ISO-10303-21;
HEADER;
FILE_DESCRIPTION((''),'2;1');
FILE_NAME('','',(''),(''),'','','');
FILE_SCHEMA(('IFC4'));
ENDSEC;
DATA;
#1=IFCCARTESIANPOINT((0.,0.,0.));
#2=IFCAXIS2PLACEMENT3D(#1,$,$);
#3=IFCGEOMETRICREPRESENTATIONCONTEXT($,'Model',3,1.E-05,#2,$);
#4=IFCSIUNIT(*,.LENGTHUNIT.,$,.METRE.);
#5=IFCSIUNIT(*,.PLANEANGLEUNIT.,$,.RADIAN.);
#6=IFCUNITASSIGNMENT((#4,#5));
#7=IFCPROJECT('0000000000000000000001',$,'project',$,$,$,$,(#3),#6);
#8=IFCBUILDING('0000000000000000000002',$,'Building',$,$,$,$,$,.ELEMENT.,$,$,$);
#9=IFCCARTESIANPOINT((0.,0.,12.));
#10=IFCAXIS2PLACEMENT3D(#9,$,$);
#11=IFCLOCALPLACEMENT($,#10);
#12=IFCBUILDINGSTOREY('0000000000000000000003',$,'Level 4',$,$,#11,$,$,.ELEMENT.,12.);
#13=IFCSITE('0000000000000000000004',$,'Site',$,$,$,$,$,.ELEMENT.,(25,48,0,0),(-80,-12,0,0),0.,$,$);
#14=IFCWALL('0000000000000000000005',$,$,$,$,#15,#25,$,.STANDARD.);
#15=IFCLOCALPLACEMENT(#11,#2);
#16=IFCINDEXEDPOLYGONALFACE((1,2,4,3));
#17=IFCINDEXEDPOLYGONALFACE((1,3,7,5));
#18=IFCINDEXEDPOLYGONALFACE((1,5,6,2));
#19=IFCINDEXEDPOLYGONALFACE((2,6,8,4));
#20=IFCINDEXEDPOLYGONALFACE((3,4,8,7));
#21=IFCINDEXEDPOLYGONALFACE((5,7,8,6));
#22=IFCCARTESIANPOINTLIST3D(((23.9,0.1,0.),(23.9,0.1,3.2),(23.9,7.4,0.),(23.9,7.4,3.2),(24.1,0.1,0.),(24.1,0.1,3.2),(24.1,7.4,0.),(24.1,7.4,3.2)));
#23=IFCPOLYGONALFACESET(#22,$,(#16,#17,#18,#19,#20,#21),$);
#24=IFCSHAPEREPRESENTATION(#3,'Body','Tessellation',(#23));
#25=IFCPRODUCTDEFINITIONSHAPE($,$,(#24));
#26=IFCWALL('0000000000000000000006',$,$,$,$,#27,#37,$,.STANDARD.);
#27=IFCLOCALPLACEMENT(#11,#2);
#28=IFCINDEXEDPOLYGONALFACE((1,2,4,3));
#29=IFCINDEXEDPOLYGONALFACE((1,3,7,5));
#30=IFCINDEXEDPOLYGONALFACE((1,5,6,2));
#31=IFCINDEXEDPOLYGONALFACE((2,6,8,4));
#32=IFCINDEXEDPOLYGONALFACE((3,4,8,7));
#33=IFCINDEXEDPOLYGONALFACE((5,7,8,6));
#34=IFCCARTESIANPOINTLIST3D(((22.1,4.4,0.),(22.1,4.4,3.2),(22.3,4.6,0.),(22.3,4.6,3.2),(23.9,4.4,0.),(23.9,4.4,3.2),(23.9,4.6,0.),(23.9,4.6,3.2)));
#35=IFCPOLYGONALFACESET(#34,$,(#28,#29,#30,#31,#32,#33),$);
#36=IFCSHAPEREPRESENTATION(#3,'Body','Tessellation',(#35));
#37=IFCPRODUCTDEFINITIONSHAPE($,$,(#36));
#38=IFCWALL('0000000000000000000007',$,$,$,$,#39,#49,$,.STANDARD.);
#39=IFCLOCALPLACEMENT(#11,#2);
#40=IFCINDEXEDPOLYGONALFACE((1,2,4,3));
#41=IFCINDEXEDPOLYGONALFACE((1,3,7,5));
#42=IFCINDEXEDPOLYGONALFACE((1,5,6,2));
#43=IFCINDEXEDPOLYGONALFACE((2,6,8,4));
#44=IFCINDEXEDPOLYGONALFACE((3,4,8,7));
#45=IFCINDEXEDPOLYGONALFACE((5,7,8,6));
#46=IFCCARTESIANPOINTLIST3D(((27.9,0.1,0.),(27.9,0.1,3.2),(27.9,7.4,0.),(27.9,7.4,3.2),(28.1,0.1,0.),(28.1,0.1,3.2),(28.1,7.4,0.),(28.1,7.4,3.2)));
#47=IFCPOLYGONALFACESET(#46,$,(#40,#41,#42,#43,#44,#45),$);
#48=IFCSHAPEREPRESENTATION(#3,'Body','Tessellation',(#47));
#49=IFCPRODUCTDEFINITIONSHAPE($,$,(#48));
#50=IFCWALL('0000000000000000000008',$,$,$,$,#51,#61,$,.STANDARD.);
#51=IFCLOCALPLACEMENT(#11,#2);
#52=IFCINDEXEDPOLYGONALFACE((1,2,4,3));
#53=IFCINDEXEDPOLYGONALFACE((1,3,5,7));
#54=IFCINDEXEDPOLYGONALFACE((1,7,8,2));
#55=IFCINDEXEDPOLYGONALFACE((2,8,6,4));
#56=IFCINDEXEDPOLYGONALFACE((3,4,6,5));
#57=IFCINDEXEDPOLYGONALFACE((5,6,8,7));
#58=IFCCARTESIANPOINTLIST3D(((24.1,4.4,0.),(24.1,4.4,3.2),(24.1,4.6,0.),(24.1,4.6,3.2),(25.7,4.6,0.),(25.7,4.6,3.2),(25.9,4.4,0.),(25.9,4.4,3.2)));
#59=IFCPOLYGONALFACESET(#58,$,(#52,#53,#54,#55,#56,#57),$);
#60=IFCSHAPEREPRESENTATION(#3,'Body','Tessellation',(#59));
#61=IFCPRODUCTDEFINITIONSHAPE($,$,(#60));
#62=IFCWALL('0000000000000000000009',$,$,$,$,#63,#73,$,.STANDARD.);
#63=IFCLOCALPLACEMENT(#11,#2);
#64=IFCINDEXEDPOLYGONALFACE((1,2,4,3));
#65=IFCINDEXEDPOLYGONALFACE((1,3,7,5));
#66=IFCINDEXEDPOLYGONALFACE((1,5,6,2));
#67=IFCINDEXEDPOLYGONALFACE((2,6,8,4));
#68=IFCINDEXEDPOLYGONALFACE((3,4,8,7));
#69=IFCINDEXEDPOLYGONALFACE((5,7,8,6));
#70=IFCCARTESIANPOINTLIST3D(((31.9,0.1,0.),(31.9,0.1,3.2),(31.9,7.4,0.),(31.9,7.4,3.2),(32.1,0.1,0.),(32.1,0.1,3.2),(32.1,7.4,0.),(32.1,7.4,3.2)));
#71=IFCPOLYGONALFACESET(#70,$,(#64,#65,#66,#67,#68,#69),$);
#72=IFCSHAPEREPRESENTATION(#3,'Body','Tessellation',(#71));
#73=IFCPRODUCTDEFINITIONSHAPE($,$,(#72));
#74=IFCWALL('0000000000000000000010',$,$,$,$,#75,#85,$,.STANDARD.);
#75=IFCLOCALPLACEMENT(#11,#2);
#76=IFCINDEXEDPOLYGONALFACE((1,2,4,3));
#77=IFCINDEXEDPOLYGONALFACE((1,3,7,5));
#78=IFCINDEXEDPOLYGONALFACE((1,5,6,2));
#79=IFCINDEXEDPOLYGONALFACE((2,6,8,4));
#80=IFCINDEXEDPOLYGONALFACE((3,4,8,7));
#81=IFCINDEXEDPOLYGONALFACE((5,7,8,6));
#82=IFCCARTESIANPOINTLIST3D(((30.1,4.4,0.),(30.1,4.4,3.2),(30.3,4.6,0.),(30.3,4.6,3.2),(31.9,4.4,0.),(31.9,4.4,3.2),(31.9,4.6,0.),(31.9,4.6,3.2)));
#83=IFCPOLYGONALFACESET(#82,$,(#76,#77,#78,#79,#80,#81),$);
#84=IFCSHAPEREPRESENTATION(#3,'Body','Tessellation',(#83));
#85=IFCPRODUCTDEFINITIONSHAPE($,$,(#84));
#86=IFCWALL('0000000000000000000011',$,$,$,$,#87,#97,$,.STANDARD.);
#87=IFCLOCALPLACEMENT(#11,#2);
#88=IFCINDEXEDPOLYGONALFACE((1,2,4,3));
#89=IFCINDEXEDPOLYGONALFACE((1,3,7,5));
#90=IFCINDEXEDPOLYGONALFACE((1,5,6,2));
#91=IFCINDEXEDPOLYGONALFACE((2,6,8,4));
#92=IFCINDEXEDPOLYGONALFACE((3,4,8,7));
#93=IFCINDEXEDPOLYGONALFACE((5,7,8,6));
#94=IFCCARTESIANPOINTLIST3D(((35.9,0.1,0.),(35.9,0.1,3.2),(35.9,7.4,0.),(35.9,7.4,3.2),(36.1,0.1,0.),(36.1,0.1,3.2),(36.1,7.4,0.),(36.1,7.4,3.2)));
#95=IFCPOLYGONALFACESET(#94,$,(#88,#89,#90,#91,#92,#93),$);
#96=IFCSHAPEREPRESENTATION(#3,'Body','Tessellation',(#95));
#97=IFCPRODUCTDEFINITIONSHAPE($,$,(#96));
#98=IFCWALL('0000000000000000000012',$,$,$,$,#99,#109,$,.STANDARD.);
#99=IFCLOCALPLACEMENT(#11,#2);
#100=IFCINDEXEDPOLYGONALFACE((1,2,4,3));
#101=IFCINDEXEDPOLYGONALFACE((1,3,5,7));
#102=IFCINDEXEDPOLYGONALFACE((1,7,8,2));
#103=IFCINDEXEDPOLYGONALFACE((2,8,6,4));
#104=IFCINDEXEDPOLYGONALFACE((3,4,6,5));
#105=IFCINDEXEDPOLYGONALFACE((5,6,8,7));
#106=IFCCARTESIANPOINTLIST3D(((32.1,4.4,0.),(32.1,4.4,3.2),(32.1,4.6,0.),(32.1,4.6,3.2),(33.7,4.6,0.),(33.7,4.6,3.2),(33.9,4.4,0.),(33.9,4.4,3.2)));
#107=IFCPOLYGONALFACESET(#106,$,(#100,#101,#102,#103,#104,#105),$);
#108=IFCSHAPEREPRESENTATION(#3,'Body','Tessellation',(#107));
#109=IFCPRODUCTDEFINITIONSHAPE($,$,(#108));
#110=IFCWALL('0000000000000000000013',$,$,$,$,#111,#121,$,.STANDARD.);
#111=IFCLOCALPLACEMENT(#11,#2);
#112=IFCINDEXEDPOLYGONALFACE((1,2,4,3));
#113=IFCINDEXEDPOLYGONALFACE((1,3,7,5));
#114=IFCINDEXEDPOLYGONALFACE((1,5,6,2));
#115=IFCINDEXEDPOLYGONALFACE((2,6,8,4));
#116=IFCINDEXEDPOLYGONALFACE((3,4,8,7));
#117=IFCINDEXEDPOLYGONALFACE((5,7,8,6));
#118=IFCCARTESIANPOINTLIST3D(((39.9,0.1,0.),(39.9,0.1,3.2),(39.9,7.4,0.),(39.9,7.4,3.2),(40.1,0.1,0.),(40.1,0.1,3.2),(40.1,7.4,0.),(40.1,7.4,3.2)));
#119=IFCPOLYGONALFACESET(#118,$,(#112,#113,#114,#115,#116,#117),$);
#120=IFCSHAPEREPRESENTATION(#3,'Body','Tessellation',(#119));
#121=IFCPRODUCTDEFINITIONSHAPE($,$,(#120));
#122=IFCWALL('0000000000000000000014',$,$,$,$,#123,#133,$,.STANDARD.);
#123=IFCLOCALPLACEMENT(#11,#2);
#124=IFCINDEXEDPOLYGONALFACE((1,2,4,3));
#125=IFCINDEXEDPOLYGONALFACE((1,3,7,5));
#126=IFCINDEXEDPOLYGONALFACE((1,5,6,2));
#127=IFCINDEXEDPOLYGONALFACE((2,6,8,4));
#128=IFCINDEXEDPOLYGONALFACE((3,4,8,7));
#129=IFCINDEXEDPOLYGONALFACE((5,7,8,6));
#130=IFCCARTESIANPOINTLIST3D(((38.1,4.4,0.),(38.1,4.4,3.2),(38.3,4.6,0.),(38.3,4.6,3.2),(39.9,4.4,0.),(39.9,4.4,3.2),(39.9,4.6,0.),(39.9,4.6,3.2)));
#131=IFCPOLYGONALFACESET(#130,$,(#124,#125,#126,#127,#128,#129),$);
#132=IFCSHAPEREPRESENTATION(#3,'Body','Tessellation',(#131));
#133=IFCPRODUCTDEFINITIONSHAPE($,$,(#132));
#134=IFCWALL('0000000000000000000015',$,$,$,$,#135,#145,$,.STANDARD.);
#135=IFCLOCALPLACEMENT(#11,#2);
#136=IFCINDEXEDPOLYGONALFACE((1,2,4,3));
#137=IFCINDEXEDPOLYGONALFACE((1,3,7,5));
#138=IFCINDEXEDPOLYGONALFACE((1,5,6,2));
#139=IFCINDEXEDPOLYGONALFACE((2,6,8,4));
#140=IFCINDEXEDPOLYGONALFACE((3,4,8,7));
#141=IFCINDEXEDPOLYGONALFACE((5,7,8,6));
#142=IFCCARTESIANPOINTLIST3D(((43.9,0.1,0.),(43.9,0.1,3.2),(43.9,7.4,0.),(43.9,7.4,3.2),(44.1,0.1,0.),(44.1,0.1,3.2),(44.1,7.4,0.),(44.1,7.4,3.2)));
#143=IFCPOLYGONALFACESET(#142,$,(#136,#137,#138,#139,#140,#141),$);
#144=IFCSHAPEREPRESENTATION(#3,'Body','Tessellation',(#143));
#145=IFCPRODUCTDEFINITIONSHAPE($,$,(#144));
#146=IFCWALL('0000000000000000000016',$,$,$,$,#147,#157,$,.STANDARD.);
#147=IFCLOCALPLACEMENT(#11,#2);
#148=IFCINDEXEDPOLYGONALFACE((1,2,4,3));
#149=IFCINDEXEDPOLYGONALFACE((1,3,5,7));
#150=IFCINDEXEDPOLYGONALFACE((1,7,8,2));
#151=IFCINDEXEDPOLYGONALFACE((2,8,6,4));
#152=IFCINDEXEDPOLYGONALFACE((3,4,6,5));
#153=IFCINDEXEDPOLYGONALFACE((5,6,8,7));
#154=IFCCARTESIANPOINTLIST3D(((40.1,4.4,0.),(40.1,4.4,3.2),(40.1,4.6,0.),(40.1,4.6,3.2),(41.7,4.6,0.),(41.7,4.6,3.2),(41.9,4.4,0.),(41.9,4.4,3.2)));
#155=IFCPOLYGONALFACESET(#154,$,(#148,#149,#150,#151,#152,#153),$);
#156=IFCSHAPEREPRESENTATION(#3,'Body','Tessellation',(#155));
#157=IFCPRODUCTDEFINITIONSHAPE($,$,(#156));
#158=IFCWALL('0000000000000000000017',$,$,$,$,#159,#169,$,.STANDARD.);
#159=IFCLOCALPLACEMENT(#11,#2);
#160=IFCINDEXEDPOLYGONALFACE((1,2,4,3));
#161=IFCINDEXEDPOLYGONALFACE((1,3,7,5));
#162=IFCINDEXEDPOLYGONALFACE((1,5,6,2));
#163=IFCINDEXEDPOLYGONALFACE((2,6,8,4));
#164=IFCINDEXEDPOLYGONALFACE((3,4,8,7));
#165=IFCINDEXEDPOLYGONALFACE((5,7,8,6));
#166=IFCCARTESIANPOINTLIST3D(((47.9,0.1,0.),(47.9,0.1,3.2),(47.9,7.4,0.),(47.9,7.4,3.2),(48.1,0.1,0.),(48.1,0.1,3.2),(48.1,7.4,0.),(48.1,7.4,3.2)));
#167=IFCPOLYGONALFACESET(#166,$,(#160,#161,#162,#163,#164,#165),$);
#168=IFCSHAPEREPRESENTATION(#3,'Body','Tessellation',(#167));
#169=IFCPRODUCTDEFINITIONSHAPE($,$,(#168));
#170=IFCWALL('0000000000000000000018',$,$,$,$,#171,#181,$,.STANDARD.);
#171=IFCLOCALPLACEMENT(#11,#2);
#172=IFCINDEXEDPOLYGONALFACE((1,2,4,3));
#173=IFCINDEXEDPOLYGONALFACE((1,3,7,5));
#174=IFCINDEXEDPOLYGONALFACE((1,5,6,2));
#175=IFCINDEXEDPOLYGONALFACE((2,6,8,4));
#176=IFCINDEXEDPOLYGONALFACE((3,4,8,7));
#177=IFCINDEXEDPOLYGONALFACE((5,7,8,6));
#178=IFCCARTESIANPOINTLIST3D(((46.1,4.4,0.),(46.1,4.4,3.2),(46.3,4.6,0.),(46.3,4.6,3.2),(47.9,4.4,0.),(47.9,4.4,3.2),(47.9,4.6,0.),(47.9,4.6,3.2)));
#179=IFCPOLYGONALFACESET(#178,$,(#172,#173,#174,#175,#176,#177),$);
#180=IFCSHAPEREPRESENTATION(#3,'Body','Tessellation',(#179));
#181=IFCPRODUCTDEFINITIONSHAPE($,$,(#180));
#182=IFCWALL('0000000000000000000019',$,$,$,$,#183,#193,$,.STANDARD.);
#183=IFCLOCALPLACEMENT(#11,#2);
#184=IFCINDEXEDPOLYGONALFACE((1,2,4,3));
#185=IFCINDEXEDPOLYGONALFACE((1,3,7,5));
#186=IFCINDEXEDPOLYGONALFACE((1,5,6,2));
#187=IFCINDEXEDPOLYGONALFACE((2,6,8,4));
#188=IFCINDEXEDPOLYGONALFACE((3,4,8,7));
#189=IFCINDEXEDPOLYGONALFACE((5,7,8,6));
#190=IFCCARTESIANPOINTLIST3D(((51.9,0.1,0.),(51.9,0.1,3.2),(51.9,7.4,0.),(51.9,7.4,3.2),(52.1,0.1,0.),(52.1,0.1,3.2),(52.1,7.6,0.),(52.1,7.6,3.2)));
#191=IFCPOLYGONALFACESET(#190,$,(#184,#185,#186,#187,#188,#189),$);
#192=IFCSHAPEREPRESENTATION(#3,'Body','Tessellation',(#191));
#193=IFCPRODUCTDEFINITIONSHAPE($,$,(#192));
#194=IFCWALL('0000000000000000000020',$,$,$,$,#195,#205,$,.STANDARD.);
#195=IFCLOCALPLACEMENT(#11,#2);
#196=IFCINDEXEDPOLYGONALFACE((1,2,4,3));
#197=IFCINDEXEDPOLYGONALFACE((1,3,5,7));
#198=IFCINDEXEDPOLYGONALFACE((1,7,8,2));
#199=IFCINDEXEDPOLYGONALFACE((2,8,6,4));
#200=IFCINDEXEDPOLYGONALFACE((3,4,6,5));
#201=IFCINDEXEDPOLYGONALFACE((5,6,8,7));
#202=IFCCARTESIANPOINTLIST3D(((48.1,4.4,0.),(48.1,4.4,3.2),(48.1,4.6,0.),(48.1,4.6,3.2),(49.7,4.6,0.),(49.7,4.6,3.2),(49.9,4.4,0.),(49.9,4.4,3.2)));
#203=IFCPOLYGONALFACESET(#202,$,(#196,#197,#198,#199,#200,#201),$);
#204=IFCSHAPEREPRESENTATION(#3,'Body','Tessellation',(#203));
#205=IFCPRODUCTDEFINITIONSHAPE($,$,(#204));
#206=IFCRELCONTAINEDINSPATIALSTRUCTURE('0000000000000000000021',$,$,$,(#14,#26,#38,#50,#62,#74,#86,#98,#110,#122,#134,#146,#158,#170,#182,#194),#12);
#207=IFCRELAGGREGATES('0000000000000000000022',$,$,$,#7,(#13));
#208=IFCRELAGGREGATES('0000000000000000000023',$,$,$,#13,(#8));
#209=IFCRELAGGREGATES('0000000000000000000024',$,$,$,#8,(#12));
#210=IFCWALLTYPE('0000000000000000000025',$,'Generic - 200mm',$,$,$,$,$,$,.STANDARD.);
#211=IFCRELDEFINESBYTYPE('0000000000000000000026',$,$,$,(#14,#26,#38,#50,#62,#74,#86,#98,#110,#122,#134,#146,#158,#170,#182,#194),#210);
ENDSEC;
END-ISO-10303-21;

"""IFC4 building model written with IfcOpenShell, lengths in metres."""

from ifc_helpers import new_model, si_unit, frame, origin, place, context, project, spatial, polyline, outline, extrude, type_object, element, save


model = new_model("IFC4")

# Units and contexts
model_context = context("Model", 3, precision=1e-05, world=origin())
ifc_project = project(units=[si_unit("LENGTHUNIT", "METRE"), si_unit("PLANEANGLEUNIT", "RADIAN")], contexts=[model_context])

# Site, building, storey
site = spatial("IfcSite", under=ifc_project, Name="Site", CompositionType="ELEMENT", RefLatitude=(25, 48, 0, 0), RefLongitude=(-80, -12, 0, 0), RefElevation=0.0)
building = spatial("IfcBuilding", under=site, Name="Building", CompositionType="ELEMENT")
storey_placement = place(None, frame((0.0, 0.0, 12.0)))
storey = spatial("IfcBuildingStorey", under=building, at=storey_placement, Name="Level 4", CompositionType="ELEMENT", Elevation=12.0)

# Shared definitions
wall_type = type_object("IfcWallType", Name="Generic - 200mm", PredefinedType="STANDARD")

# Walls
wall_1_placement = place(None, frame((24.0, 7.5, 12.0), z_axis=(0.0, 0.0, 1.0), x_axis=(0.0, -1.0, 0.0)))
element("IfcWall", 1, at=wall_1_placement, inside=storey, type_object=wall_type, PredefinedType="STANDARD", context=model_context, shape_type="SweptSolid", body=[
    extrude(outline(polyline([(0.1, -0.1), (7.4, -0.1), (7.4, 0.1), (0.1, 0.1), (0.1, -0.1)])), origin(), (0.0, 0.0, 1.0), 3.2),
])
wall_2_placement = place(None, frame((22.2, 4.5, 12.0), z_axis=(0.0, 0.0, 1.0), x_axis=(1.0, 0.0, 0.0)))
element("IfcWall", 2, at=wall_2_placement, inside=storey, type_object=wall_type, PredefinedType="STANDARD", context=model_context, shape_type="SweptSolid", body=[
    extrude(outline(polyline([(-0.1, -0.1), (1.7, -0.1), (1.7, 0.1), (0.1, 0.1), (-0.1, -0.1)])), origin(), (0.0, 0.0, 1.0), 3.2),
])
wall_3_placement = place(None, frame((28.0, 7.5, 12.0), z_axis=(0.0, 0.0, 1.0), x_axis=(0.0, -1.0, 0.0)))
element("IfcWall", 3, at=wall_3_placement, inside=storey, type_object=wall_type, PredefinedType="STANDARD", context=model_context, shape_type="SweptSolid", body=[
    extrude(outline(polyline([(0.1, -0.1), (7.4, -0.1), (7.4, 0.1), (0.1, 0.1), (0.1, -0.1)])), origin(), (0.0, 0.0, 1.0), 3.2),
])
wall_4_placement = place(None, frame((25.8, 4.5, 12.0), z_axis=(0.0, 0.0, 1.0), x_axis=(-1.0, 0.0, 0.0)))
element("IfcWall", 4, at=wall_4_placement, inside=storey, type_object=wall_type, PredefinedType="STANDARD", context=model_context, shape_type="SweptSolid", body=[
    extrude(outline(polyline([(0.1, -0.1), (1.7, -0.1), (1.7, 0.1), (-0.1, 0.1), (0.1, -0.1)])), origin(), (0.0, 0.0, 1.0), 3.2),
])
wall_5_placement = place(None, frame((32.0, 7.5, 12.0), z_axis=(0.0, 0.0, 1.0), x_axis=(0.0, -1.0, 0.0)))
element("IfcWall", 5, at=wall_5_placement, inside=storey, type_object=wall_type, PredefinedType="STANDARD", context=model_context, shape_type="SweptSolid", body=[
    extrude(outline(polyline([(0.1, -0.1), (7.4, -0.1), (7.4, 0.1), (0.1, 0.1), (0.1, -0.1)])), origin(), (0.0, 0.0, 1.0), 3.2),
])
wall_6_placement = place(None, frame((30.2, 4.5, 12.0), z_axis=(0.0, 0.0, 1.0), x_axis=(1.0, 0.0, 0.0)))
element("IfcWall", 6, at=wall_6_placement, inside=storey, type_object=wall_type, PredefinedType="STANDARD", context=model_context, shape_type="SweptSolid", body=[
    extrude(outline(polyline([(-0.1, -0.1), (1.7, -0.1), (1.7, 0.1), (0.1, 0.1), (-0.1, -0.1)])), origin(), (0.0, 0.0, 1.0), 3.2),
])
wall_7_placement = place(None, frame((36.0, 7.5, 12.0), z_axis=(0.0, 0.0, 1.0), x_axis=(0.0, -1.0, 0.0)))
element("IfcWall", 7, at=wall_7_placement, inside=storey, type_object=wall_type, PredefinedType="STANDARD", context=model_context, shape_type="SweptSolid", body=[
    extrude(outline(polyline([(0.1, -0.1), (7.4, -0.1), (7.4, 0.1), (0.1, 0.1), (0.1, -0.1)])), origin(), (0.0, 0.0, 1.0), 3.2),
])
wall_8_placement = place(None, frame((33.8, 4.5, 12.0), z_axis=(0.0, 0.0, 1.0), x_axis=(-1.0, 0.0, 0.0)))
element("IfcWall", 8, at=wall_8_placement, inside=storey, type_object=wall_type, PredefinedType="STANDARD", context=model_context, shape_type="SweptSolid", body=[
    extrude(outline(polyline([(0.1, -0.1), (1.7, -0.1), (1.7, 0.1), (-0.1, 0.1), (0.1, -0.1)])), origin(), (0.0, 0.0, 1.0), 3.2),
])
wall_9_placement = place(None, frame((40.0, 7.5, 12.0), z_axis=(0.0, 0.0, 1.0), x_axis=(0.0, -1.0, 0.0)))
element("IfcWall", 9, at=wall_9_placement, inside=storey, type_object=wall_type, PredefinedType="STANDARD", context=model_context, shape_type="SweptSolid", body=[
    extrude(outline(polyline([(0.1, -0.1), (7.4, -0.1), (7.4, 0.1), (0.1, 0.1), (0.1, -0.1)])), origin(), (0.0, 0.0, 1.0), 3.2),
])
wall_10_placement = place(None, frame((38.2, 4.5, 12.0), z_axis=(0.0, 0.0, 1.0), x_axis=(1.0, 0.0, 0.0)))
element("IfcWall", 10, at=wall_10_placement, inside=storey, type_object=wall_type, PredefinedType="STANDARD", context=model_context, shape_type="SweptSolid", body=[
    extrude(outline(polyline([(-0.1, -0.1), (1.7, -0.1), (1.7, 0.1), (0.1, 0.1), (-0.1, -0.1)])), origin(), (0.0, 0.0, 1.0), 3.2),
])
wall_11_placement = place(None, frame((44.0, 7.5, 12.0), z_axis=(0.0, 0.0, 1.0), x_axis=(0.0, -1.0, 0.0)))
element("IfcWall", 11, at=wall_11_placement, inside=storey, type_object=wall_type, PredefinedType="STANDARD", context=model_context, shape_type="SweptSolid", body=[
    extrude(outline(polyline([(0.1, -0.1), (7.4, -0.1), (7.4, 0.1), (0.1, 0.1), (0.1, -0.1)])), origin(), (0.0, 0.0, 1.0), 3.2),
])
wall_12_placement = place(None, frame((41.8, 4.5, 12.0), z_axis=(0.0, 0.0, 1.0), x_axis=(-1.0, 0.0, 0.0)))
element("IfcWall", 12, at=wall_12_placement, inside=storey, type_object=wall_type, PredefinedType="STANDARD", context=model_context, shape_type="SweptSolid", body=[
    extrude(outline(polyline([(0.1, -0.1), (1.7, -0.1), (1.7, 0.1), (-0.1, 0.1), (0.1, -0.1)])), origin(), (0.0, 0.0, 1.0), 3.2),
])
wall_13_placement = place(None, frame((48.0, 7.5, 12.0), z_axis=(0.0, 0.0, 1.0), x_axis=(0.0, -1.0, 0.0)))
element("IfcWall", 13, at=wall_13_placement, inside=storey, type_object=wall_type, PredefinedType="STANDARD", context=model_context, shape_type="SweptSolid", body=[
    extrude(outline(polyline([(0.1, -0.1), (7.4, -0.1), (7.4, 0.1), (0.1, 0.1), (0.1, -0.1)])), origin(), (0.0, 0.0, 1.0), 3.2),
])
wall_14_placement = place(None, frame((46.2, 4.5, 12.0), z_axis=(0.0, 0.0, 1.0), x_axis=(1.0, 0.0, 0.0)))
element("IfcWall", 14, at=wall_14_placement, inside=storey, type_object=wall_type, PredefinedType="STANDARD", context=model_context, shape_type="SweptSolid", body=[
    extrude(outline(polyline([(-0.1, -0.1), (1.7, -0.1), (1.7, 0.1), (0.1, 0.1), (-0.1, -0.1)])), origin(), (0.0, 0.0, 1.0), 3.2),
])
wall_15_placement = place(None, frame((52.0, 7.5, 12.0), z_axis=(0.0, 0.0, 1.0), x_axis=(0.0, -1.0, 0.0)))
element("IfcWall", 15, at=wall_15_placement, inside=storey, type_object=wall_type, PredefinedType="STANDARD", context=model_context, shape_type="SweptSolid", body=[
    extrude(outline(polyline([(0.1, -0.1), (7.4, -0.1), (7.4, 0.1), (-0.1, 0.1), (0.1, -0.1)])), origin(), (0.0, 0.0, 1.0), 3.2),
])
wall_16_placement = place(None, frame((49.8, 4.5, 12.0), z_axis=(0.0, 0.0, 1.0), x_axis=(-1.0, 0.0, 0.0)))
element("IfcWall", 16, at=wall_16_placement, inside=storey, type_object=wall_type, PredefinedType="STANDARD", context=model_context, shape_type="SweptSolid", body=[
    extrude(outline(polyline([(0.1, -0.1), (1.7, -0.1), (1.7, 0.1), (-0.1, 0.1), (0.1, -0.1)])), origin(), (0.0, 0.0, 1.0), 3.2),
])

save(model, "model.ifc")
